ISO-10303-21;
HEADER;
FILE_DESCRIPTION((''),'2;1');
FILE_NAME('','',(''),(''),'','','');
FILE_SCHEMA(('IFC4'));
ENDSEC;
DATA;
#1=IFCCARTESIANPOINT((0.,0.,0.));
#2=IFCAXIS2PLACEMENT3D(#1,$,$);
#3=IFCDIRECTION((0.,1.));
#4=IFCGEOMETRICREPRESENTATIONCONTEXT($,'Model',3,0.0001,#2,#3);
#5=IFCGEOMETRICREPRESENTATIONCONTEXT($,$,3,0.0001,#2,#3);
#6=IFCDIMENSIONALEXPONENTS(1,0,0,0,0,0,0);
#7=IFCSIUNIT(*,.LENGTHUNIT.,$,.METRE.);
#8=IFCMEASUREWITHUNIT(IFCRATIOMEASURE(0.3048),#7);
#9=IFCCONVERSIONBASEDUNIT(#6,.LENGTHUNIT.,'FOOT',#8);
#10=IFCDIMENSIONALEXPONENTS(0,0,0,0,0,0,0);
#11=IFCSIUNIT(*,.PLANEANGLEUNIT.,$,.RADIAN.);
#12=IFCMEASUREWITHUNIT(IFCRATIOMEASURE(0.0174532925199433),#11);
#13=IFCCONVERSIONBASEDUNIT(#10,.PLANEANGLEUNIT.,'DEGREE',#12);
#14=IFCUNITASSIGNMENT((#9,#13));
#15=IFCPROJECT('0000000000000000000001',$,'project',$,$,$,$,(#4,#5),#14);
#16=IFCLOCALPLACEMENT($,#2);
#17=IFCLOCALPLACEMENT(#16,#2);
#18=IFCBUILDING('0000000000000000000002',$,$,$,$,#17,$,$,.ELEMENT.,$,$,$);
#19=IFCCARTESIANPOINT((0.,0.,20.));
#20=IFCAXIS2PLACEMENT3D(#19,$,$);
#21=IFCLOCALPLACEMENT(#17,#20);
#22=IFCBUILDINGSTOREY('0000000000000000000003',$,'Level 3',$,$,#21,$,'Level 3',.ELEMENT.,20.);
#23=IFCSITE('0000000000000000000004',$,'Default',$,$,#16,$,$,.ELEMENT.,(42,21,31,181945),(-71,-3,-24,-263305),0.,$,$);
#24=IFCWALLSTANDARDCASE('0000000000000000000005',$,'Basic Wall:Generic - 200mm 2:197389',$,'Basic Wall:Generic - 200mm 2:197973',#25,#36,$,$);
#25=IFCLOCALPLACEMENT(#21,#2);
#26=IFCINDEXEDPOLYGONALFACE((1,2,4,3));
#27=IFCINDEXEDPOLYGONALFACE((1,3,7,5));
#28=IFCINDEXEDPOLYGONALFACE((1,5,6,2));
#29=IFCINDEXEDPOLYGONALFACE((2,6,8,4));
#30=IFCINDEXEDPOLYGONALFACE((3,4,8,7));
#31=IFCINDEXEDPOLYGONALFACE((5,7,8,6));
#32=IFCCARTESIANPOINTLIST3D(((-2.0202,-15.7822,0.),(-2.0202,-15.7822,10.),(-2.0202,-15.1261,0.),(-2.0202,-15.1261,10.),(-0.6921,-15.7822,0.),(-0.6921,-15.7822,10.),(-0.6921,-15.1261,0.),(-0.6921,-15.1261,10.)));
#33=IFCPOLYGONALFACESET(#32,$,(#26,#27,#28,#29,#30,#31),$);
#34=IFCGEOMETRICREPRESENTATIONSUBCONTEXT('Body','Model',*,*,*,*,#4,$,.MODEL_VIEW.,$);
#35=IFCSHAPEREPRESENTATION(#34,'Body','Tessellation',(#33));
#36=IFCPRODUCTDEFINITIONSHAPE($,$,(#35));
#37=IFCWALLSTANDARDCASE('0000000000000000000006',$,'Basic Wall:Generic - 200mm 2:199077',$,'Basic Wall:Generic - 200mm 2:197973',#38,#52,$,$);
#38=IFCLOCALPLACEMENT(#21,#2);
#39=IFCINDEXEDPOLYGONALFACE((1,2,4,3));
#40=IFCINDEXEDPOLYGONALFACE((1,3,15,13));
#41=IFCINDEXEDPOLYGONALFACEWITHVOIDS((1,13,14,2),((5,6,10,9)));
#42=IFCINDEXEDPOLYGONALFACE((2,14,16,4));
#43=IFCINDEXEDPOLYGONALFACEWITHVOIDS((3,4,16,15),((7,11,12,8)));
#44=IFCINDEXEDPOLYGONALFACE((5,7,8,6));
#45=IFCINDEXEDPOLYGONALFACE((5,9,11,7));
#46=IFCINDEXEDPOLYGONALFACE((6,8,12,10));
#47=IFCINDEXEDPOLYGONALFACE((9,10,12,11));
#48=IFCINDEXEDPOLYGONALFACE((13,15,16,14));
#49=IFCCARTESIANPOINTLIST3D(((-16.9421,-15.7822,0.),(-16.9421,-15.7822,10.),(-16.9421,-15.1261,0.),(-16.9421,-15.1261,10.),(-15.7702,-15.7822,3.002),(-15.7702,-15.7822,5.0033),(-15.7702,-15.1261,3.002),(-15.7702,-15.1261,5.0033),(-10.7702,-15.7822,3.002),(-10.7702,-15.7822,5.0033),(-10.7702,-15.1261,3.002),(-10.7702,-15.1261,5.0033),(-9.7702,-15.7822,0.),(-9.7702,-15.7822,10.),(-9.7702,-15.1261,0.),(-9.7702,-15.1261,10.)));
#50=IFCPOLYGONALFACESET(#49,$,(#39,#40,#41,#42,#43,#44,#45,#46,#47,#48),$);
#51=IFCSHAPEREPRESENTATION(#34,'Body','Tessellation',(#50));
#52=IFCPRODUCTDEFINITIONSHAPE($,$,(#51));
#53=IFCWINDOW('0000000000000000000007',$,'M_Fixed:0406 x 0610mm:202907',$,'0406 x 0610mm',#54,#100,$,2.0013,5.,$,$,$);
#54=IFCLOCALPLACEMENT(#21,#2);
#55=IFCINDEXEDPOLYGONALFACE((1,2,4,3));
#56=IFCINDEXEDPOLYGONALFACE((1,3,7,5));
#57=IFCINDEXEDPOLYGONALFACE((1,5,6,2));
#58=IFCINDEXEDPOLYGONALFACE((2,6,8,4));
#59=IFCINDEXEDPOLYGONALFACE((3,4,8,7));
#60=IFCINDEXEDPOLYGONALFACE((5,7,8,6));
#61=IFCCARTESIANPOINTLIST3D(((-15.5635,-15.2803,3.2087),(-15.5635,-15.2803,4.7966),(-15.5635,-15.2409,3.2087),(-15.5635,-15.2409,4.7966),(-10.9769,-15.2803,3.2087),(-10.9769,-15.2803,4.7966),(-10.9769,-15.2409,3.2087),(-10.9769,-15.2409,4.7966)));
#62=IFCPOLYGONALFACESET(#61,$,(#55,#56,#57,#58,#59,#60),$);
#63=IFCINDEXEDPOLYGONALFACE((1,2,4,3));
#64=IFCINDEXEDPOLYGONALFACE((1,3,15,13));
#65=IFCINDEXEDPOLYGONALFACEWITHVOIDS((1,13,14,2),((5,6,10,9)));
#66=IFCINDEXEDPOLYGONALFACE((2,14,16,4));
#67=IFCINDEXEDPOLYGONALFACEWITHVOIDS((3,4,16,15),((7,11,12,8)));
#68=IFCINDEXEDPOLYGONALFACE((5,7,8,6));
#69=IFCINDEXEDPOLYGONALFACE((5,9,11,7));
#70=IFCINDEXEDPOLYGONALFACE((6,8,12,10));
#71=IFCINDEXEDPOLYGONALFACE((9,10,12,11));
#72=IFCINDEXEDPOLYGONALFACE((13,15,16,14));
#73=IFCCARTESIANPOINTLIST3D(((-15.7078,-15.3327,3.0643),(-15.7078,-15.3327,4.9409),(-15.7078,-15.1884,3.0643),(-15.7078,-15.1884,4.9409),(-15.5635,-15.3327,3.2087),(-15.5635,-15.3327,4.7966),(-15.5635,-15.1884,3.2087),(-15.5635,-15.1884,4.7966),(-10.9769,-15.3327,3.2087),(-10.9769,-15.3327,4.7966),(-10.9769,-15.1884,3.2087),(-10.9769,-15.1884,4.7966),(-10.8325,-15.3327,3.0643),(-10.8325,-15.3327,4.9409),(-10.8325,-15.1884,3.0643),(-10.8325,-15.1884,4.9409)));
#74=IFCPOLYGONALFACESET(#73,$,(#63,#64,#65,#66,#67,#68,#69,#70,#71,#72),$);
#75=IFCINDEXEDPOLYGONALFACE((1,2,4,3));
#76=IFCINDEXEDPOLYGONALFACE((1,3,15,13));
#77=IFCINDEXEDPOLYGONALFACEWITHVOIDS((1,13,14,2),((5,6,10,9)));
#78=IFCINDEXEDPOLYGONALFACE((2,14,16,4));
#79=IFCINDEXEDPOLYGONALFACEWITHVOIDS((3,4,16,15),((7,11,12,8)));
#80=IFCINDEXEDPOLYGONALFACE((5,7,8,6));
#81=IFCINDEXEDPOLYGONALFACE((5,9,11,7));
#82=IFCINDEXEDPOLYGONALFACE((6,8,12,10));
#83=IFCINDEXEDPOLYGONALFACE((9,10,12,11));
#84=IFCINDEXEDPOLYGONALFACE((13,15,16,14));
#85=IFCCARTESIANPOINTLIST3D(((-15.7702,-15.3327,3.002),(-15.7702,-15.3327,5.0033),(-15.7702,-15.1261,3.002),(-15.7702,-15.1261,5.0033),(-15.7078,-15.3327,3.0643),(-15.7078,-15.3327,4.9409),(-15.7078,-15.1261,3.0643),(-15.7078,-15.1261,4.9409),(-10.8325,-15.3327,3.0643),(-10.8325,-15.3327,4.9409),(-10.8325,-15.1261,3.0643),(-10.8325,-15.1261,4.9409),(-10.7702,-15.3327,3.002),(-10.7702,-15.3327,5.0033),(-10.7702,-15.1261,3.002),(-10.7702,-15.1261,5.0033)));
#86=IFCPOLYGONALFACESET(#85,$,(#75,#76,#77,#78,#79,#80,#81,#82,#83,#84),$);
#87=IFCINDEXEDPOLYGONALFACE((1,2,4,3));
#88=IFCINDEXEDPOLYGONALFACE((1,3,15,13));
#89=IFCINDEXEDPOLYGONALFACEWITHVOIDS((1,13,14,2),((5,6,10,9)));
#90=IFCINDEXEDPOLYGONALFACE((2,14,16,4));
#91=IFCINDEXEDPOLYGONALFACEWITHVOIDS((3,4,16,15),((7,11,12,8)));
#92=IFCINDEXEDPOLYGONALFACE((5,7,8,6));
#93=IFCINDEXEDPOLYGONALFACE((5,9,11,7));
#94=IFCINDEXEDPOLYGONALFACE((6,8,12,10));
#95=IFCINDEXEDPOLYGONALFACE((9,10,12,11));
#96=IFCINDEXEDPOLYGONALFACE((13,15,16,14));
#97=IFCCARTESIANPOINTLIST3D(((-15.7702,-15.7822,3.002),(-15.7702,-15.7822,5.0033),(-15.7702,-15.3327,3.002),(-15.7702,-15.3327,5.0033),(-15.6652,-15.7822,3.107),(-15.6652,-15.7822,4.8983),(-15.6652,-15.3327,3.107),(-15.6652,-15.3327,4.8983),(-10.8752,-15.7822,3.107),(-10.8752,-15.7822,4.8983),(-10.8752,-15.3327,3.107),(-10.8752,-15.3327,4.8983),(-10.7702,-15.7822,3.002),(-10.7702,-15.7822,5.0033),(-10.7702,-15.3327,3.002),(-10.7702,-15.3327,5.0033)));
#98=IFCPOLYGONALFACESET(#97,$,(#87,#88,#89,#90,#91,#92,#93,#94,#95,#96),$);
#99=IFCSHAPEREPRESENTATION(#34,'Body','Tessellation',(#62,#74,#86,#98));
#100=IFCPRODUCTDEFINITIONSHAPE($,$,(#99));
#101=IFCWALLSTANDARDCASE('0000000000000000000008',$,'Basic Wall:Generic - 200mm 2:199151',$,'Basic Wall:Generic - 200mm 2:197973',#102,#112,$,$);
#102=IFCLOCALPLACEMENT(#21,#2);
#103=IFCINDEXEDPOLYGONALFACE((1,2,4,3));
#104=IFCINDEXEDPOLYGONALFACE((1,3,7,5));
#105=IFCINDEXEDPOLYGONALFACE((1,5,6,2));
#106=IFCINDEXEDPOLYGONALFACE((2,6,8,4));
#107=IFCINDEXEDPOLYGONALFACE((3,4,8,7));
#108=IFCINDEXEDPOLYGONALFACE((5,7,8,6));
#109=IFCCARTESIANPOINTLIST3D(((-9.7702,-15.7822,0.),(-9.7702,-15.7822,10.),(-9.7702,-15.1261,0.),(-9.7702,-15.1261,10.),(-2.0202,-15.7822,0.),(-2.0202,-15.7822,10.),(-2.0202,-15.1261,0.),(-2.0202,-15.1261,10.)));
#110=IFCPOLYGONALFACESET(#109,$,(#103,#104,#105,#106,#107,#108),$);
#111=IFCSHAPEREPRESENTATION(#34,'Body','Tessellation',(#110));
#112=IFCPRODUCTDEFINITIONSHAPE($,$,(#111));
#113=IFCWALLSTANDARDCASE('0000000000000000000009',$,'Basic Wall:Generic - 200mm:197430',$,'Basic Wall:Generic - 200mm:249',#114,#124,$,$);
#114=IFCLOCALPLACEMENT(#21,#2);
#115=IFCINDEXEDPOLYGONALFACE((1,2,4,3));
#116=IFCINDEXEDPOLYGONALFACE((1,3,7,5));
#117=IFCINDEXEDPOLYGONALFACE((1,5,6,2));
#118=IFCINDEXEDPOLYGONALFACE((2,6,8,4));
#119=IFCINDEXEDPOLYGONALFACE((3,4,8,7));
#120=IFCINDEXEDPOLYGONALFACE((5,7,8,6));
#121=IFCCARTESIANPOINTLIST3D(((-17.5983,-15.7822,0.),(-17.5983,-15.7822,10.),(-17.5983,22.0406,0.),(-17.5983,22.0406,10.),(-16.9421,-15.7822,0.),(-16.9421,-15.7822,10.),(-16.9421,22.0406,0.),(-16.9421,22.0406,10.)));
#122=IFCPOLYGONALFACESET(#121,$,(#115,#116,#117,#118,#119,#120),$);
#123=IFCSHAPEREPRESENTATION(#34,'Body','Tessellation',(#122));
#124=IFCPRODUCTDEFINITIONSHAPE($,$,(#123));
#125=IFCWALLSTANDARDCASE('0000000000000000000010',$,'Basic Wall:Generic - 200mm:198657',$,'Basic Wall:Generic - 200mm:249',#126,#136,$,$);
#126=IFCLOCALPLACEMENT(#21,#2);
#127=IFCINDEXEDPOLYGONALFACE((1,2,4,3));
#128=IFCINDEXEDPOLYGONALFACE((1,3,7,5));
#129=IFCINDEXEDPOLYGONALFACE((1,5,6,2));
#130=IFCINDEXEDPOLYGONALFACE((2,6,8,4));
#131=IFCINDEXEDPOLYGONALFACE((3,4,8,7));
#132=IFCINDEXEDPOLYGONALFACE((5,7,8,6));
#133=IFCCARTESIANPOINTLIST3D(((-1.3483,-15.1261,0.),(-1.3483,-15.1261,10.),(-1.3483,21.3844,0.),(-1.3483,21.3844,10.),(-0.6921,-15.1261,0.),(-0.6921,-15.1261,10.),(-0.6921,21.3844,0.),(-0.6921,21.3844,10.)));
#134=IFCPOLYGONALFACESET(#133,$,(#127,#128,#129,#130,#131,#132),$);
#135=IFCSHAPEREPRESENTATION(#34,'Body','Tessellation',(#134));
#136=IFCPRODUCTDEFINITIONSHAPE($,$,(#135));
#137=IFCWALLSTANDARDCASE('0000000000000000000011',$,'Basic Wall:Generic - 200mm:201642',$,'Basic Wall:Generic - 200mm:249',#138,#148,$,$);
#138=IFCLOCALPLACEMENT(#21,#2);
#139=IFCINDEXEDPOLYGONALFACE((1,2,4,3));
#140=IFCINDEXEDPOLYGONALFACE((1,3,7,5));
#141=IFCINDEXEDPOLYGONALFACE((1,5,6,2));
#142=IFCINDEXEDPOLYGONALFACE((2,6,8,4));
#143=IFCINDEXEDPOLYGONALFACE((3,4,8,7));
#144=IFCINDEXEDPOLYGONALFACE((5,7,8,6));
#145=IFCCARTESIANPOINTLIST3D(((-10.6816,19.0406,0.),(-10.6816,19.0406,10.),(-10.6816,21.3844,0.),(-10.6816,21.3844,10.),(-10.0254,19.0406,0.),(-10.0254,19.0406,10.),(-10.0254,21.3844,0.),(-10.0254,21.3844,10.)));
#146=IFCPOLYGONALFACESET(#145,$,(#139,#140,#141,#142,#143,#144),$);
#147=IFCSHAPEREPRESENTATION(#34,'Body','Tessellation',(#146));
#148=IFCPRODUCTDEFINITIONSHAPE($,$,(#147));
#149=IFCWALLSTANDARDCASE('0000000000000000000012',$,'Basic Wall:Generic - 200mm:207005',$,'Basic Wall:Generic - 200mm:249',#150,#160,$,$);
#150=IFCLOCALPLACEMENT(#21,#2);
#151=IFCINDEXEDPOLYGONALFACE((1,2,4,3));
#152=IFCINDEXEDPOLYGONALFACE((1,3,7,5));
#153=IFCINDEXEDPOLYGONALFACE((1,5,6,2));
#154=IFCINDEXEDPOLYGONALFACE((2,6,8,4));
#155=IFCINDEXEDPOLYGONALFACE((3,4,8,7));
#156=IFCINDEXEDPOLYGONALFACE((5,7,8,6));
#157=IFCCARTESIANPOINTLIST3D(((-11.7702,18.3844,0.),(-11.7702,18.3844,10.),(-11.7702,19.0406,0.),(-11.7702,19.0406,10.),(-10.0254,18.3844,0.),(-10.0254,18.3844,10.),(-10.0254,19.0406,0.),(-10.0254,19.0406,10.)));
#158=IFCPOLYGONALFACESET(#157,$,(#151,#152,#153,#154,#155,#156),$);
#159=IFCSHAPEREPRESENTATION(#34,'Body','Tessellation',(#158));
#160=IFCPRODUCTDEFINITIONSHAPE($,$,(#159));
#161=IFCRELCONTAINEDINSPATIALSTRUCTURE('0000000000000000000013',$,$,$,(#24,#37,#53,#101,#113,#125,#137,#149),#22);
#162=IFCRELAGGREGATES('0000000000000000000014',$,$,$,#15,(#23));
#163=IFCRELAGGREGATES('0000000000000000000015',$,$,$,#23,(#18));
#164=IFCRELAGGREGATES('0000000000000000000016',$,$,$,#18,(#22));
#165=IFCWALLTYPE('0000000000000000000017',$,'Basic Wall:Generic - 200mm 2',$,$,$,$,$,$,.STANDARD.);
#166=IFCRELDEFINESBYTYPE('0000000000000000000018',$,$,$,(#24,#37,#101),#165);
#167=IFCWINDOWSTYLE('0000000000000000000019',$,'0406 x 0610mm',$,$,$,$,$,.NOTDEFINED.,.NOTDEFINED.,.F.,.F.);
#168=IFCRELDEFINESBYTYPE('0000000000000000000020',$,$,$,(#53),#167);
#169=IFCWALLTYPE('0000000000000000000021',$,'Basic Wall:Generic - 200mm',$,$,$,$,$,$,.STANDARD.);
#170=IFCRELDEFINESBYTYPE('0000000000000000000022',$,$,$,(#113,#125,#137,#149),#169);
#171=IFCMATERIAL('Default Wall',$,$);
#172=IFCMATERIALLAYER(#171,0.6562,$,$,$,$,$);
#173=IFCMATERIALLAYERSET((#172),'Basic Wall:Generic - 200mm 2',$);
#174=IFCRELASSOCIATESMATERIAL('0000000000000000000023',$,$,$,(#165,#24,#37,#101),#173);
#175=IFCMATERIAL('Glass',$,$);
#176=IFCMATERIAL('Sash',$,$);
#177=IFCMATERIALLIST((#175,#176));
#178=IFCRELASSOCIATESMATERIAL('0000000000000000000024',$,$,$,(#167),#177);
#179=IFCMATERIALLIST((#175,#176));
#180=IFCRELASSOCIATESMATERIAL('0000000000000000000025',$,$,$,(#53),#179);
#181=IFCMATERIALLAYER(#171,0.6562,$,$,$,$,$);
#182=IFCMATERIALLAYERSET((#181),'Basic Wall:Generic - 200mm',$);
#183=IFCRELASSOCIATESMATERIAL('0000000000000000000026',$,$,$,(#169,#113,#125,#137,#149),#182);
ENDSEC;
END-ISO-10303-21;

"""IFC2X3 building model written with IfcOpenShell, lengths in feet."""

from ifc_helpers import new_model, entity, si_unit, converted_unit, direction, frame, frame_2d, origin, place, context, subcontext, project, spatial, polyline, rectangle, outline, extrude, clip, halfspace, source, transform, mapped, material, material_list, layer, layer_set, layer_usage, type_object, type_shapes, element, fill, save


model = new_model("IFC2X3")

# Units and contexts
model_context = context("Model", 3, precision=0.0001, world=origin(), true_north=direction((0.0, 1.0)))
context_of_model = context(None, 3, precision=0.0001, world=origin(), true_north=direction((0.0, 1.0)))
body_context = subcontext(model_context, "Body", "Model", "MODEL_VIEW")
ifc_project = project(units=[converted_unit("LENGTHUNIT", "FOOT", entity("IfcRatioMeasure", 0.3048), si_unit("LENGTHUNIT", "METRE"), dimensions=[1, 0, 0, 0, 0, 0, 0]), converted_unit("PLANEANGLEUNIT", "DEGREE", entity("IfcRatioMeasure", 0.0174532925199433), si_unit("PLANEANGLEUNIT", "RADIAN"), dimensions=[0, 0, 0, 0, 0, 0, 0])], contexts=[model_context, context_of_model])

# Site, building, storey
site_placement = place(None, origin())
site = spatial("IfcSite", under=ifc_project, at=site_placement, Name="Default", CompositionType="ELEMENT", RefLatitude=(42, 21, 31, 181945), RefLongitude=(-71, -3, -24, -263305), RefElevation=0.0)
building_placement = place(site_placement, origin())
building = spatial("IfcBuilding", under=site, at=building_placement, CompositionType="ELEMENT")
storey_placement = place(building_placement, frame((0.0, 0.0, 20.0)))
storey = spatial("IfcBuildingStorey", under=building, at=storey_placement, Name="Level 3", LongName="Level 3", CompositionType="ELEMENT", Elevation=20.0)

# Shared definitions
ifc_material_1 = material(Name="Glass")

# Wall
ifc_material_2 = material(Name="Default Wall")
ifc_layer_1 = layer(ifc_material_2, 0.6562)
ifc_layer_set_1 = layer_set([ifc_layer_1], Name="Basic Wall:Generic - 200mm 2")
ifc_layer_usage_1 = layer_usage(ifc_layer_set_1, "AXIS2", "NEGATIVE", 0.3281)
wall_type_1 = type_object("IfcWallType", Name="Basic Wall:Generic - 200mm 2", PredefinedType="STANDARD", material=ifc_layer_set_1)
wall_1_placement = place(storey_placement, frame((-0.6921, -15.4541, 0.0), z_axis=(0.0, 0.0, 1.0), x_axis=(-1.0, 0.0, 0.0)))
element("IfcWallStandardCase", 1, at=wall_1_placement, inside=storey, type_object=wall_type_1, material=ifc_layer_usage_1, Name="Basic Wall:Generic - 200mm 2:197389", ObjectType="Basic Wall:Generic - 200mm 2:197973", context=body_context, shape_type="Clipping", body=[
    clip(extrude(rectangle(XDim=1.3281, YDim=0.6562, at=frame_2d((0.664, 0.0), x_axis=(-1.0, 0.0))), origin(), (0.0, 0.0, 1.0), 10.0), halfspace(frame((0.0, 0.0, -20.0)), True)),
])

# Wall, opening, window
ifc_layer_usage_2 = layer_usage(ifc_layer_set_1, "AXIS2", "NEGATIVE", 0.3281)
wall_2_placement = place(storey_placement, frame((-9.7702, -15.4541, 0.0), z_axis=(0.0, 0.0, 1.0), x_axis=(-1.0, 0.0, 0.0)))
wall_2 = element("IfcWallStandardCase", 2, at=wall_2_placement, inside=storey, type_object=wall_type_1, material=ifc_layer_usage_2, Name="Basic Wall:Generic - 200mm 2:199077", ObjectType="Basic Wall:Generic - 200mm 2:197973", context=body_context, shape_type="Clipping", body=[
    clip(extrude(rectangle(XDim=7.1719, YDim=0.6562, at=frame_2d((3.586, 0.0), x_axis=(-1.0, 0.0))), origin(), (0.0, 0.0, 1.0), 10.0), halfspace(frame((0.0, 0.0, -20.0)), True)),
])
opening_1_placement = place(wall_2_placement, frame((6.0, 0.3281, 3.002)))
opening_1 = element("IfcOpeningElement", 3, at=opening_1_placement, cuts=wall_2, ObjectType="Opening", context=body_context, shape_type="SweptSolid", body=[
    extrude(rectangle(XDim=2.0013, YDim=5.0, at=frame_2d((1.0007, 2.5), x_axis=(1.0, 0.0))), frame((0.0, 0.0, 0.0), z_axis=(0.0, -1.0, 0.0), x_axis=(0.0, 0.0, 1.0)), (0.0, 0.0, 1.0), 0.6562),
])
ifc_material_3 = material(Name="Sash")
ifc_material_list_1 = material_list([ifc_material_1, ifc_material_3])
ifc_material_list_2 = material_list([ifc_material_1, ifc_material_3])
window_style = type_object("IfcWindowStyle", Name="0406 x 0610mm", ConstructionType="NOTDEFINED", OperationType="NOTDEFINED", ParameterTakesPrecedence=False, Sizeable=False, material=ifc_material_list_2)
shared_shape_1 = source(origin(), body_context, "Body", "SweptSolid", [
    extrude(rectangle(XDim=0.0394, YDim=4.5866, at=frame_2d((0.0, 0.0), x_axis=(1.0, 0.0))), frame((2.5, 0.5217, 0.2067), z_axis=(0.0, 0.0, 1.0), x_axis=(0.0, -1.0, 0.0)), (0.0, 0.0, 1.0), 1.5879),
    extrude(outline(polyline([(-2.4377, -0.9383), (2.4377, -0.9383), (2.4377, 0.9383), (-2.4377, 0.9383), (-2.4377, -0.9383)]), holes=[polyline([(-2.2933, -0.794), (-2.2933, 0.794), (2.2933, 0.794), (2.2933, -0.794), (-2.2933, -0.794)])]), frame((2.5, 0.4495, 1.0007), z_axis=(0.0, 1.0, 0.0), x_axis=(1.0, 0.0, 0.0)), (0.0, 0.0, 1.0), 0.1444),
    extrude(outline(polyline([(-2.5, -1.0007), (2.5, -1.0007), (2.5, 1.0007), (-2.5, 1.0007), (-2.5, -1.0007)]), holes=[polyline([(-2.4377, -0.9383), (-2.4377, 0.9383), (2.4377, 0.9383), (2.4377, -0.9383), (-2.4377, -0.9383)])]), frame((2.5, 0.4495, 1.0007), z_axis=(0.0, 1.0, 0.0), x_axis=(1.0, 0.0, 0.0)), (0.0, 0.0, 1.0), 0.2067),
    extrude(outline(polyline([(-2.5, -1.0007), (2.5, -1.0007), (2.5, 1.0007), (-2.5, 1.0007), (-2.5, -1.0007)]), holes=[polyline([(-2.395, -0.8957), (-2.395, 0.8957), (2.395, 0.8957), (2.395, -0.8957), (-2.395, -0.8957)])]), frame((2.5, 0.0, 1.0007), z_axis=(0.0, 1.0, 0.0), x_axis=(1.0, 0.0, 0.0)), (0.0, 0.0, 1.0), 0.4495),
])
type_shapes(window_style, [shared_shape_1])
window_placement = place(opening_1_placement, frame((0.0, 0.0, 0.0), z_axis=(0.0, 0.0, 1.0), x_axis=(-1.0, 0.0, 0.0)))
window = element("IfcWindow", 4, at=window_placement, inside=storey, type_object=window_style, material=ifc_material_list_1, Name="M_Fixed:0406 x 0610mm:202907", ObjectType="0406 x 0610mm", OverallHeight=2.0013, OverallWidth=5.0, context=body_context, shape_type="MappedRepresentation", body=[
    mapped(shared_shape_1, transform((0.0, 0.0, 0.0), scale=1.0)),
])
fill(opening_1, window)

# Walls
ifc_layer_usage_3 = layer_usage(ifc_layer_set_1, "AXIS2", "NEGATIVE", 0.3281)
wall_3_placement = place(storey_placement, frame((-2.0202, -15.4541, 0.0), z_axis=(0.0, 0.0, 1.0), x_axis=(-1.0, 0.0, 0.0)))
element("IfcWallStandardCase", 5, at=wall_3_placement, inside=storey, type_object=wall_type_1, material=ifc_layer_usage_3, Name="Basic Wall:Generic - 200mm 2:199151", ObjectType="Basic Wall:Generic - 200mm 2:197973", context=body_context, shape_type="Clipping", body=[
    clip(extrude(rectangle(XDim=7.75, YDim=0.6562, at=frame_2d((3.875, 0.0), x_axis=(-1.0, 0.0))), origin(), (0.0, 0.0, 1.0), 10.0), halfspace(frame((0.0, 0.0, -20.0)), True)),
])
ifc_layer_2 = layer(ifc_material_2, 0.6562)
ifc_layer_set_2 = layer_set([ifc_layer_2], Name="Basic Wall:Generic - 200mm")
ifc_layer_usage_4 = layer_usage(ifc_layer_set_2, "AXIS2", "NEGATIVE", 0.3281)
wall_type_2 = type_object("IfcWallType", Name="Basic Wall:Generic - 200mm", PredefinedType="STANDARD", material=ifc_layer_set_2)
wall_4_placement = place(storey_placement, frame((-17.2702, -15.7822, 0.0), z_axis=(0.0, 0.0, 1.0), x_axis=(0.0, 1.0, 0.0)))
element("IfcWallStandardCase", 6, at=wall_4_placement, inside=storey, type_object=wall_type_2, material=ifc_layer_usage_4, Name="Basic Wall:Generic - 200mm:197430", ObjectType="Basic Wall:Generic - 200mm:249", context=body_context, shape_type="Clipping", body=[
    clip(extrude(rectangle(XDim=37.8228, YDim=0.6562, at=frame_2d((18.9114, 0.0), x_axis=(-1.0, 0.0))), origin(), (0.0, 0.0, 1.0), 10.0), halfspace(frame((0.0, 0.0, -20.0)), True)),
])
ifc_layer_usage_5 = layer_usage(ifc_layer_set_2, "AXIS2", "NEGATIVE", 0.3281)
wall_5_placement = place(storey_placement, frame((-1.0202, -15.1261, 0.0), z_axis=(0.0, 0.0, 1.0), x_axis=(0.0, 1.0, 0.0)))
element("IfcWallStandardCase", 7, at=wall_5_placement, inside=storey, type_object=wall_type_2, material=ifc_layer_usage_5, Name="Basic Wall:Generic - 200mm:198657", ObjectType="Basic Wall:Generic - 200mm:249", context=body_context, shape_type="Clipping", body=[
    clip(extrude(rectangle(XDim=36.5105, YDim=0.6562, at=frame_2d((18.2552, 0.0), x_axis=(-1.0, 0.0))), origin(), (0.0, 0.0, 1.0), 10.0), halfspace(frame((0.0, 0.0, -20.0)), True)),
])
ifc_layer_usage_6 = layer_usage(ifc_layer_set_2, "AXIS2", "NEGATIVE", 0.3281)
wall_6_placement = place(storey_placement, frame((-10.3535, 21.3844, 0.0), z_axis=(0.0, 0.0, 1.0), x_axis=(0.0, -1.0, 0.0)))
element("IfcWallStandardCase", 8, at=wall_6_placement, inside=storey, type_object=wall_type_2, material=ifc_layer_usage_6, Name="Basic Wall:Generic - 200mm:201642", ObjectType="Basic Wall:Generic - 200mm:249", context=body_context, shape_type="SweptSolid", body=[
    extrude(rectangle(XDim=2.3438, YDim=0.6562, at=frame_2d((1.1719, 0.0), x_axis=(-1.0, 0.0))), origin(), (0.0, 0.0, 1.0), 10.0),
])
ifc_layer_usage_7 = layer_usage(ifc_layer_set_2, "AXIS2", "NEGATIVE", 0.3281)
wall_7_placement = place(storey_placement, frame((-11.7702, 18.7125, 0.0)))
element("IfcWallStandardCase", 9, at=wall_7_placement, inside=storey, type_object=wall_type_2, material=ifc_layer_usage_7, Name="Basic Wall:Generic - 200mm:207005", ObjectType="Basic Wall:Generic - 200mm:249", context=body_context, shape_type="SweptSolid", body=[
    extrude(rectangle(XDim=1.7448, YDim=0.6562, at=frame_2d((0.8724, 0.0), x_axis=(-1.0, 0.0))), origin(), (0.0, 0.0, 1.0), 10.0),
])

save(model, "model.ifc")
